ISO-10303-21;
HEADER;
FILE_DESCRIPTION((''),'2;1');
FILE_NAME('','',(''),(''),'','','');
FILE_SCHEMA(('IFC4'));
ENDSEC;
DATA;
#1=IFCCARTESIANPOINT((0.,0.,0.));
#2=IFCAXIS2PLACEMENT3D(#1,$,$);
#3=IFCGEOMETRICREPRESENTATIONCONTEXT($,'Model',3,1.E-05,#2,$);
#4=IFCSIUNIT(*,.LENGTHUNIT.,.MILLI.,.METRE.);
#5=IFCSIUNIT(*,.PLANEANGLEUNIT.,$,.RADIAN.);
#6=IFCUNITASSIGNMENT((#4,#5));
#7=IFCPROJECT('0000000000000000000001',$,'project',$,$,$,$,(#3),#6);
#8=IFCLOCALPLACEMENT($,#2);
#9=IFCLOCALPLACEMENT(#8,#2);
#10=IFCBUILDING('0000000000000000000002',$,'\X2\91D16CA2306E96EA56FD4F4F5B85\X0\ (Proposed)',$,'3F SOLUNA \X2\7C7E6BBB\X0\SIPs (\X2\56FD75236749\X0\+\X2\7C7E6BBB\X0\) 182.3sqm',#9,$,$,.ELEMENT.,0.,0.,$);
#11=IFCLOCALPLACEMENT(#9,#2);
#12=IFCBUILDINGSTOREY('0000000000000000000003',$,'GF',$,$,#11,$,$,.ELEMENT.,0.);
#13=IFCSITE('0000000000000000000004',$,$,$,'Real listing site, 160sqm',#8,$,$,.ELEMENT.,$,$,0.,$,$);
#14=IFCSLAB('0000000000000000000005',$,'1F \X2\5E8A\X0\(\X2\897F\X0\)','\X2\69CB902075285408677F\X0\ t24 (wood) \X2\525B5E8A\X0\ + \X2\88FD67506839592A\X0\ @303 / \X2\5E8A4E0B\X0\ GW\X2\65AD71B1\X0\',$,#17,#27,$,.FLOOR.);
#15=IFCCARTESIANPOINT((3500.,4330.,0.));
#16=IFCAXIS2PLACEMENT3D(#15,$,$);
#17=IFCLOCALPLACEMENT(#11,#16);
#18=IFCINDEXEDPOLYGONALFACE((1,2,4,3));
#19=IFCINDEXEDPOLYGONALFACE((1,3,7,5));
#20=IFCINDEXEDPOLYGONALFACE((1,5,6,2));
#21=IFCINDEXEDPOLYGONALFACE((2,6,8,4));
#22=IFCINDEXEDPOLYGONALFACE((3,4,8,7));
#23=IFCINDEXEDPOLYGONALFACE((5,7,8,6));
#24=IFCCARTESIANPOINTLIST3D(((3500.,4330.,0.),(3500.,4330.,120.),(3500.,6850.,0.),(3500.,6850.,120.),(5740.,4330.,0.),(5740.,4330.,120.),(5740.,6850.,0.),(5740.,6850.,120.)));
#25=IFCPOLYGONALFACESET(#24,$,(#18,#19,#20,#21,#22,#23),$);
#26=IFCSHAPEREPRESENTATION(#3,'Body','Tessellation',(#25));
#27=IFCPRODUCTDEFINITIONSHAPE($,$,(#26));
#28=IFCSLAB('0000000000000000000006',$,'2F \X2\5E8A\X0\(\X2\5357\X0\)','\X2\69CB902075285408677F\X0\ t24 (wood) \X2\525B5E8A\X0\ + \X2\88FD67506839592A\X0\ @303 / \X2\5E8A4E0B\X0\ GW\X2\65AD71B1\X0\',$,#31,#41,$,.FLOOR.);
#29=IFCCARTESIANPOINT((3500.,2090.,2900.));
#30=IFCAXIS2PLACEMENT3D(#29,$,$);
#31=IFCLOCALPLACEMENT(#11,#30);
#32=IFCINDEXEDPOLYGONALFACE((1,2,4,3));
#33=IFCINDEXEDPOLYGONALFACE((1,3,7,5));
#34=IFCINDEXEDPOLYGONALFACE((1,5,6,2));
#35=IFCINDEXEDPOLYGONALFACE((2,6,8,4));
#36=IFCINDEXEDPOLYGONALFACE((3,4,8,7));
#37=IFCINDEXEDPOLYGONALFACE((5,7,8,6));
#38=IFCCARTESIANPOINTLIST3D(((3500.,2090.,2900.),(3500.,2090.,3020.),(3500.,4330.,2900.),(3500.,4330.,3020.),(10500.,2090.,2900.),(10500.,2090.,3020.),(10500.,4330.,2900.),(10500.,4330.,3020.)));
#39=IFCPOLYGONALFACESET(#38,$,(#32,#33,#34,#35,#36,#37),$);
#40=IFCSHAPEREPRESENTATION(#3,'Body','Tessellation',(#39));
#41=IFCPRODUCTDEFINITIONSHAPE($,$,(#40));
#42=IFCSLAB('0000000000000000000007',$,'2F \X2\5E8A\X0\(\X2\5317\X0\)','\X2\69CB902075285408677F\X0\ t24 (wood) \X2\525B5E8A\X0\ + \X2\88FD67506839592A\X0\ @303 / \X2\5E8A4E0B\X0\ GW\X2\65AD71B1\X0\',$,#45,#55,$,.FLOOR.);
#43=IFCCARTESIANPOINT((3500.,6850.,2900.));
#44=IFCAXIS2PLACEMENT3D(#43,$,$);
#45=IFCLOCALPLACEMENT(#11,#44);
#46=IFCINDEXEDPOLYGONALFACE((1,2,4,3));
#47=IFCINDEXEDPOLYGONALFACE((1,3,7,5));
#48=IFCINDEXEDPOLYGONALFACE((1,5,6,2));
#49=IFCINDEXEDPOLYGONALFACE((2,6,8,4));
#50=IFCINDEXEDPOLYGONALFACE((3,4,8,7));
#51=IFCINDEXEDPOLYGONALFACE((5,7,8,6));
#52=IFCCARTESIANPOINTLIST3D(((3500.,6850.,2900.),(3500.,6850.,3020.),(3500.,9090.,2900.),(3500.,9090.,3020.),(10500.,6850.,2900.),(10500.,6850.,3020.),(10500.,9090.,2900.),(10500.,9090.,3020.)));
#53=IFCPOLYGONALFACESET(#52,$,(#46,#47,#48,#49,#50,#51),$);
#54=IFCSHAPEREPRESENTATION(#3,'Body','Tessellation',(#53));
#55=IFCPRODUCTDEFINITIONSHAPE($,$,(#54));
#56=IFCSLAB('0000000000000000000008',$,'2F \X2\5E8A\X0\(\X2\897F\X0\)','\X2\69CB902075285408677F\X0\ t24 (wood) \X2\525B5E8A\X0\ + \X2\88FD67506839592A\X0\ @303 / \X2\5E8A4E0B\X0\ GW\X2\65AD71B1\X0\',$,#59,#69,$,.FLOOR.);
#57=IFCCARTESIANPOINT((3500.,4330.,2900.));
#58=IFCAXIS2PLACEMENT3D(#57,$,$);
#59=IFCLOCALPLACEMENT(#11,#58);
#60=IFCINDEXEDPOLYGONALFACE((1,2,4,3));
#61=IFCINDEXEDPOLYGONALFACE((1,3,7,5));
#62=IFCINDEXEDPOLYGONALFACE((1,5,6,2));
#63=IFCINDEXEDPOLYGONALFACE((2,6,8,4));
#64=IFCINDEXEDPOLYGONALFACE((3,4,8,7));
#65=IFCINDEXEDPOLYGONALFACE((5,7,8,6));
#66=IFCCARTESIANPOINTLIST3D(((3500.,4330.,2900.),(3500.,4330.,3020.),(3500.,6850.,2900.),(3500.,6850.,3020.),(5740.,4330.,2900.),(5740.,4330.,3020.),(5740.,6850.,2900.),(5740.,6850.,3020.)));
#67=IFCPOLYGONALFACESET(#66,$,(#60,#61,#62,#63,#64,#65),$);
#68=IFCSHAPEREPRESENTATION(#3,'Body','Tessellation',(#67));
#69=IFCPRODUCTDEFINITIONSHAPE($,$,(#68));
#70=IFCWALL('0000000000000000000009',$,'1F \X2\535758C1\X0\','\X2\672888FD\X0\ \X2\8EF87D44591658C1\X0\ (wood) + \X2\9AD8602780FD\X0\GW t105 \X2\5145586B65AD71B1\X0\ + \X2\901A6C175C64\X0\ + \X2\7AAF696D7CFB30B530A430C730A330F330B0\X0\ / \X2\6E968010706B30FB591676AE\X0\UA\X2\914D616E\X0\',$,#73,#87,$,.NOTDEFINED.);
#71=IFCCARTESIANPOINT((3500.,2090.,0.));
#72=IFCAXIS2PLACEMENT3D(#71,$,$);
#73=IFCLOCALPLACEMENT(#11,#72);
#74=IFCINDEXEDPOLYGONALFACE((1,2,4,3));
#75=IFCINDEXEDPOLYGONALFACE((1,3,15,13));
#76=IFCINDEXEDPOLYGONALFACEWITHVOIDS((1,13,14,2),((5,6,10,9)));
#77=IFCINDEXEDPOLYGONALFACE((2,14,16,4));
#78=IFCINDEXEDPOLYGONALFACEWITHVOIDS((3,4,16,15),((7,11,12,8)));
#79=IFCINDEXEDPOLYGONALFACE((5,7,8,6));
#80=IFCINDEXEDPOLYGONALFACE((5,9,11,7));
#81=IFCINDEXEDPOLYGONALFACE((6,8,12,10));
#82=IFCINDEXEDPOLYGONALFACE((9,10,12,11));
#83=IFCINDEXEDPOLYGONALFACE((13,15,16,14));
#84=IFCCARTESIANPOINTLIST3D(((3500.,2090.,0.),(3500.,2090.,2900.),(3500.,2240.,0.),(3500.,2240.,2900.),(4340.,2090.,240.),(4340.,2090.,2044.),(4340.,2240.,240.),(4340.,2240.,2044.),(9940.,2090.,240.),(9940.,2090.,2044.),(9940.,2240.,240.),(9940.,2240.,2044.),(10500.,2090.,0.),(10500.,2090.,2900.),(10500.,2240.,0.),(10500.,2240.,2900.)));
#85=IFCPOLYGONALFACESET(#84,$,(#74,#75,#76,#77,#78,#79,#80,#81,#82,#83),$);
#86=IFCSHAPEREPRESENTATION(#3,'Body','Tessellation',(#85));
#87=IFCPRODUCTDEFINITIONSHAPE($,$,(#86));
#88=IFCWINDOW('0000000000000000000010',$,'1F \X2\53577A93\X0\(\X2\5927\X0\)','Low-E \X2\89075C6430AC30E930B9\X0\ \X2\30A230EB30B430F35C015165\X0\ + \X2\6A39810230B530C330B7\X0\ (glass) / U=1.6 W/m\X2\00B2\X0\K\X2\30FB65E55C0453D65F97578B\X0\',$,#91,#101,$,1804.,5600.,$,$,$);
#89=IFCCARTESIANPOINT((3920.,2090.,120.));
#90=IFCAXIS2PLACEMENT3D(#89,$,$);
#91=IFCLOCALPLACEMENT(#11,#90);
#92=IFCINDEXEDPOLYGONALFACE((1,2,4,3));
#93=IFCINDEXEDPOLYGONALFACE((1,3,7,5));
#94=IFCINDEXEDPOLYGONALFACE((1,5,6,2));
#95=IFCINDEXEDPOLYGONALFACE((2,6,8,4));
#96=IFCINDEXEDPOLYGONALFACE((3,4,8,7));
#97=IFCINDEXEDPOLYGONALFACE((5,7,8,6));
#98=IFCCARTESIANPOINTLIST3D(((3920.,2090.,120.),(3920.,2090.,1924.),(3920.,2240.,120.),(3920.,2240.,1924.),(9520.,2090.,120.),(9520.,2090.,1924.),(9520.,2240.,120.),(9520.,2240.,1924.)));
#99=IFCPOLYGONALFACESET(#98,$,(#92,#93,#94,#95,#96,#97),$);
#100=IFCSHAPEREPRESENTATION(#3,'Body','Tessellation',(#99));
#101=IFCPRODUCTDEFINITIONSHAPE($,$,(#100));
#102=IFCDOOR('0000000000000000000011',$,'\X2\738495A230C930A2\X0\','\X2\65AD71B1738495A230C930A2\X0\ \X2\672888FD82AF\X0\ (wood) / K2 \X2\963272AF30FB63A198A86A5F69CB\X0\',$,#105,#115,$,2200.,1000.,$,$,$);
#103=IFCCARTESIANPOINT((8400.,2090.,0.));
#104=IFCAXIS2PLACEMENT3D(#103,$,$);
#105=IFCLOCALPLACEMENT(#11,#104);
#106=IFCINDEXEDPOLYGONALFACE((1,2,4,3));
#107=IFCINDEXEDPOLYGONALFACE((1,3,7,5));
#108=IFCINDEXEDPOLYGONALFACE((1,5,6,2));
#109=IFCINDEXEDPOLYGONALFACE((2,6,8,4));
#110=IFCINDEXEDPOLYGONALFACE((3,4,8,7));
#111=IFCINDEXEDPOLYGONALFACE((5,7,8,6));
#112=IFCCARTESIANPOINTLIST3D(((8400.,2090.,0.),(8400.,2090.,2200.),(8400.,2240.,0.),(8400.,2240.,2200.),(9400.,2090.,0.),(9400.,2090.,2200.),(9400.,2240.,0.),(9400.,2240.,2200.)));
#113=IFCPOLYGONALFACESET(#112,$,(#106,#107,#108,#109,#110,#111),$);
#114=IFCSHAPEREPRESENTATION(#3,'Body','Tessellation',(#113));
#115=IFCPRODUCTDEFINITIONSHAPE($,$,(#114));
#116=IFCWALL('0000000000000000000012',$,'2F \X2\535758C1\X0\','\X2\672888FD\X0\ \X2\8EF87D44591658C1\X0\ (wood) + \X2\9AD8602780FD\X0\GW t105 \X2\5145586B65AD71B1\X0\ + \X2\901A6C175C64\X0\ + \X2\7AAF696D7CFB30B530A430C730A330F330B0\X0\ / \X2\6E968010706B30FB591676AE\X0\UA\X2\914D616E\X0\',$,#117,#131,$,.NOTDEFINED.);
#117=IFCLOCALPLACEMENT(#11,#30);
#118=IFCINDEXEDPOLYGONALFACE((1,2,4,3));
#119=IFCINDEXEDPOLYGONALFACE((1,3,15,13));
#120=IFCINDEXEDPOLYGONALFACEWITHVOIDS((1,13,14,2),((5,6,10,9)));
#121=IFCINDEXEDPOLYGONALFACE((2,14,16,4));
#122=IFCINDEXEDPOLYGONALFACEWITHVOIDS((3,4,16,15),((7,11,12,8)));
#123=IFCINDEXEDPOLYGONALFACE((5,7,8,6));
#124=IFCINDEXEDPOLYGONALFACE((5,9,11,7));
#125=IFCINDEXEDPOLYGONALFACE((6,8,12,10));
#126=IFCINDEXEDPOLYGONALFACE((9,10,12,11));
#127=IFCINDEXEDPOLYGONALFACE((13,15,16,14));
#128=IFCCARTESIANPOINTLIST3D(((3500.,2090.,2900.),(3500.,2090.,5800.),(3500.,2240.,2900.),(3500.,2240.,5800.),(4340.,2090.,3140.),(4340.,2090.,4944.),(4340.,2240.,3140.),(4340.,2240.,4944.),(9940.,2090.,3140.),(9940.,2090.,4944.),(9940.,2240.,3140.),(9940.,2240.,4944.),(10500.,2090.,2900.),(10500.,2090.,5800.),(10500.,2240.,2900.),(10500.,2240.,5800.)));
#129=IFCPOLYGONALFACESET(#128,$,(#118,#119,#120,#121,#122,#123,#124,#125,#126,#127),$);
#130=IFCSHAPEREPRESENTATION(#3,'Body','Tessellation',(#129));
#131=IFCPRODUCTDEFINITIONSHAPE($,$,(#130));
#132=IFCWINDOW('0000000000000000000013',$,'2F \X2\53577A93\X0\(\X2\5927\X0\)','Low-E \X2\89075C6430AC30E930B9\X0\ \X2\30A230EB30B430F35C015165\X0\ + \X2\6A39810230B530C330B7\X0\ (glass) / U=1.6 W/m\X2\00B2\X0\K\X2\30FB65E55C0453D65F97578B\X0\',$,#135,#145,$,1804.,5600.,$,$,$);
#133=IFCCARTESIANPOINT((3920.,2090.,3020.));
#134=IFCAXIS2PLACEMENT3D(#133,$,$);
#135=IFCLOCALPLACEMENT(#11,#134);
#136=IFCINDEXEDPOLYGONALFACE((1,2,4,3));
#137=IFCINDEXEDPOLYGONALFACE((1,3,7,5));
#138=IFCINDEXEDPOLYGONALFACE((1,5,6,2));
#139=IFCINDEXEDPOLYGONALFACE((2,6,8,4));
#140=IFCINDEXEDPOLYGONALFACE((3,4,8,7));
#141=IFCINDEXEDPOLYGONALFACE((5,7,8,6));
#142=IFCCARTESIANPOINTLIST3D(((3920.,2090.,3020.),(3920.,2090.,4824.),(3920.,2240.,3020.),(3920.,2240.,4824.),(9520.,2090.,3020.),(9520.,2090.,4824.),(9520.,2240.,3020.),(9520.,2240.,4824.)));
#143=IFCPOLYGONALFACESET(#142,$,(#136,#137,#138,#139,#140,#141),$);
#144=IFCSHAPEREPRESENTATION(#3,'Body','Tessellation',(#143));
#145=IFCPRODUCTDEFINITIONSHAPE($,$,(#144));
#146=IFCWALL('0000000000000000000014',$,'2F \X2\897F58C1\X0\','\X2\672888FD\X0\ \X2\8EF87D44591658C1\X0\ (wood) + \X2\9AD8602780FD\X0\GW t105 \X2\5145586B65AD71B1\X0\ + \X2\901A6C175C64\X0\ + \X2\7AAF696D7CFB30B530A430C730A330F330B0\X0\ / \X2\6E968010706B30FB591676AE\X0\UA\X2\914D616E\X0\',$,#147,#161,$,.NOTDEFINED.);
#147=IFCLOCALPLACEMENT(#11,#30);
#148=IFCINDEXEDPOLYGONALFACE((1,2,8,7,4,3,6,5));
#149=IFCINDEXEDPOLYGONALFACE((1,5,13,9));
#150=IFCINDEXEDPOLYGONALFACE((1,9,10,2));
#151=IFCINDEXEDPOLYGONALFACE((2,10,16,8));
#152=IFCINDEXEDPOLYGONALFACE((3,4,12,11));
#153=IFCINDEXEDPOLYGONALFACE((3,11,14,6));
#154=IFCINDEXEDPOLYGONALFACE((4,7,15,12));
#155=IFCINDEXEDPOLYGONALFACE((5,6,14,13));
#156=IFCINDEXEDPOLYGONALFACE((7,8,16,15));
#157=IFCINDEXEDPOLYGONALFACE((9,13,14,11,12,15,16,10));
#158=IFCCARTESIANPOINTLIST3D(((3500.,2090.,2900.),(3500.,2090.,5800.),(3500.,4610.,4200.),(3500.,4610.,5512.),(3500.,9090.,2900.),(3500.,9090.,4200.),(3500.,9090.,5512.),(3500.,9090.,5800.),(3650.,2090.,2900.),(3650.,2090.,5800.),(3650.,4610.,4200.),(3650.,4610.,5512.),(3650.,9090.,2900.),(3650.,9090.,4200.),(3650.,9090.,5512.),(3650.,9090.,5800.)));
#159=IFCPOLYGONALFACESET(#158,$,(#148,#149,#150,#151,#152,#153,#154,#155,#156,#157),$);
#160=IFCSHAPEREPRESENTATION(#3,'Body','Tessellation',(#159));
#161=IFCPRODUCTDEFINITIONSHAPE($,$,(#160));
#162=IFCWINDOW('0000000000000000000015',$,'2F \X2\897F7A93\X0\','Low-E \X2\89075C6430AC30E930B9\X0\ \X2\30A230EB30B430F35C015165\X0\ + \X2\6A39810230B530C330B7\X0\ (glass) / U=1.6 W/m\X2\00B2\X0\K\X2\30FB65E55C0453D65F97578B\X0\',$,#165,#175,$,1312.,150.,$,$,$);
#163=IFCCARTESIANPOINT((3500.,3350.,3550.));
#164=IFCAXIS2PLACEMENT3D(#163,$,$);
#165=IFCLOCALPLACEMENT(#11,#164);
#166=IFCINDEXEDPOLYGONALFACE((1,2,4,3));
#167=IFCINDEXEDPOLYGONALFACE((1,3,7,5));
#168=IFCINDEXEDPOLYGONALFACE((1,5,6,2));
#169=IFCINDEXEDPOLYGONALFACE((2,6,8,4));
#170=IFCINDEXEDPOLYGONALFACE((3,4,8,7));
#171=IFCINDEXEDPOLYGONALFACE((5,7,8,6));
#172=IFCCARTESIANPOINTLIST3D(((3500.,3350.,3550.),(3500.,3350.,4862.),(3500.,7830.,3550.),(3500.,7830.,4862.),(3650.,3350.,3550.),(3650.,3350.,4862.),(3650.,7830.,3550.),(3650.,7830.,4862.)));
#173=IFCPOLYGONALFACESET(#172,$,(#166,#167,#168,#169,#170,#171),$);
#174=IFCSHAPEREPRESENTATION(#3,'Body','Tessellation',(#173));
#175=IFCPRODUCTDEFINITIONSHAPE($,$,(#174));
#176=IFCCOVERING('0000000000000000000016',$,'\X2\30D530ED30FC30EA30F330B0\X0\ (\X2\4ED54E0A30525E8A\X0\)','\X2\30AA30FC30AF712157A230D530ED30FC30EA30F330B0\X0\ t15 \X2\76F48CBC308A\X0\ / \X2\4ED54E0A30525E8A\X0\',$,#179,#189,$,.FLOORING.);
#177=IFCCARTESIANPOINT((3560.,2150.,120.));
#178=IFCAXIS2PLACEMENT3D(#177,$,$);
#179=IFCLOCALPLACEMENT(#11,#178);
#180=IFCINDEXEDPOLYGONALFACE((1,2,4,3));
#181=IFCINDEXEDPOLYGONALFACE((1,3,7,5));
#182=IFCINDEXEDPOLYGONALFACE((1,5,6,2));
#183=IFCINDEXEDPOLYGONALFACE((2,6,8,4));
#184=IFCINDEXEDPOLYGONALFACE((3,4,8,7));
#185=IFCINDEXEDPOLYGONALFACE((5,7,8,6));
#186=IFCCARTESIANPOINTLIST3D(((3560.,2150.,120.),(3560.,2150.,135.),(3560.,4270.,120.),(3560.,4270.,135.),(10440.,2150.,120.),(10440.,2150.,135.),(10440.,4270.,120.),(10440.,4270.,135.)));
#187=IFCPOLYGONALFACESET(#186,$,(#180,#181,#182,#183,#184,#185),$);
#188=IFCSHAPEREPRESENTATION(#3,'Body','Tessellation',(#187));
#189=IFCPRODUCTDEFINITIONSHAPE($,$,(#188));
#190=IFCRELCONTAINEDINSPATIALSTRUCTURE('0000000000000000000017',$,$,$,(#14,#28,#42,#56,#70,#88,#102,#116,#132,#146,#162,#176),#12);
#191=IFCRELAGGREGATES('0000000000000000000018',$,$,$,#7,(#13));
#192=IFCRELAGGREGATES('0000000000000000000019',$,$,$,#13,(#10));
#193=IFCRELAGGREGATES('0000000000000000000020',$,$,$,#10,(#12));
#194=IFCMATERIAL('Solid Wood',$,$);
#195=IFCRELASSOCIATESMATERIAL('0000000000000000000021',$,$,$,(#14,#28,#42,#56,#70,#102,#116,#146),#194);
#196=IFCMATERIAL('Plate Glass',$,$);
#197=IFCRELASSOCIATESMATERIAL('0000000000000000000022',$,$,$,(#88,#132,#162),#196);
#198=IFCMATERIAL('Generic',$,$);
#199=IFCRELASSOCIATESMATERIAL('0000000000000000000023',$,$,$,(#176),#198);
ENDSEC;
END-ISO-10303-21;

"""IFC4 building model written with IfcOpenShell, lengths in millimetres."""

from ifc_helpers import new_model, si_unit, frame, frame_2d, origin, place, context, project, spatial, rectangle, extrude, material, element, fill, save


model = new_model("IFC4")

# Units and contexts
model_context = context("Model", 3, precision=1e-05, world=origin())
ifc_project = project(units=[si_unit("LENGTHUNIT", "METRE", prefix="MILLI"), si_unit("PLANEANGLEUNIT", "RADIAN")], contexts=[model_context])

# Site, building, storey
site_placement = place(None, origin())
site = spatial("IfcSite", under=ifc_project, at=site_placement, ObjectType="Real listing site, 160sqm", CompositionType="ELEMENT", RefElevation=0.0)
building_placement = place(site_placement, origin())
building = spatial("IfcBuilding", under=site, at=building_placement, Name="金沢の雪国住宅 (Proposed)", ObjectType="3F SOLUNA 籾殻SIPs (国産杉+籾殻) 182.3sqm", CompositionType="ELEMENT", ElevationOfRefHeight=0.0, ElevationOfTerrain=0.0)
storey_placement = place(building_placement, origin())
storey = spatial("IfcBuildingStorey", under=building, at=storey_placement, Name="GF", CompositionType="ELEMENT", Elevation=0.0)

# Slabs
ifc_material_1 = material(Name="Solid Wood")
slab_1_placement = place(storey_placement, frame((3500.0, 4330.0, 0.0)))
element("IfcSlab", 1, at=slab_1_placement, inside=storey, material=ifc_material_1, Name="1F 床(西)", Description="構造用合板 t24 (wood) 剛床 + 製材根太 @303 / 床下 GW断熱", PredefinedType="FLOOR", context=model_context, shape_type="SweptSolid", body=[
    extrude(rectangle(XDim=2240.0, YDim=2520.0, at=frame_2d((1120.0, 1260.0))), frame((3500.0, 4330.0, 0.0)), (0.0, 0.0, 1.0), 120.0),
])
slab_2_placement = place(storey_placement, frame((3500.0, 2090.0, 2900.0)))
element("IfcSlab", 2, at=slab_2_placement, inside=storey, material=ifc_material_1, Name="2F 床(南)", Description="構造用合板 t24 (wood) 剛床 + 製材根太 @303 / 床下 GW断熱", PredefinedType="FLOOR", context=model_context, shape_type="SweptSolid", body=[
    extrude(rectangle(XDim=7000.0, YDim=2240.0, at=frame_2d((3500.0, 1120.0))), frame((3500.0, 2090.0, 2900.0)), (0.0, 0.0, 1.0), 120.0),
])
slab_3_placement = place(storey_placement, frame((3500.0, 6850.0, 2900.0)))
element("IfcSlab", 3, at=slab_3_placement, inside=storey, material=ifc_material_1, Name="2F 床(北)", Description="構造用合板 t24 (wood) 剛床 + 製材根太 @303 / 床下 GW断熱", PredefinedType="FLOOR", context=model_context, shape_type="SweptSolid", body=[
    extrude(rectangle(XDim=7000.0, YDim=2240.0, at=frame_2d((3500.0, 1120.0))), frame((3500.0, 6850.0, 2900.0)), (0.0, 0.0, 1.0), 120.0),
])
slab_4_placement = place(storey_placement, frame((3500.0, 4330.0, 2900.0)))
element("IfcSlab", 4, at=slab_4_placement, inside=storey, material=ifc_material_1, Name="2F 床(西)", Description="構造用合板 t24 (wood) 剛床 + 製材根太 @303 / 床下 GW断熱", PredefinedType="FLOOR", context=model_context, shape_type="SweptSolid", body=[
    extrude(rectangle(XDim=2240.0, YDim=2520.0, at=frame_2d((1120.0, 1260.0))), frame((3500.0, 4330.0, 2900.0)), (0.0, 0.0, 1.0), 120.0),
])

# Wall, openings, window, door
wall_1_placement = place(storey_placement, frame((3500.0, 2090.0, 0.0)))
wall_1 = element("IfcWall", 5, at=wall_1_placement, inside=storey, material=ifc_material_1, Name="1F 南壁", Description="木製 軸組外壁 (wood) + 高性能GW t105 充填断熱 + 通気層 + 窯業系サイディング / 準耐火・外皮UA配慮", PredefinedType="NOTDEFINED", context=model_context, shape_type="SweptSolid", body=[
    extrude(rectangle(XDim=7000.0, YDim=150.0, at=frame_2d((3500.0, 75.0))), frame((3500.0, 2090.0, 0.0)), (0.0, 0.0, 1.0), 2900.0),
])
opening_1_placement = place(storey_placement, frame((3920.0, 2090.0, 120.0)))
opening_1 = element("IfcOpeningElement", 6, at=opening_1_placement, cuts=wall_1, PredefinedType="NOTDEFINED", context=model_context, shape_type="SweptSolid", body=[
    extrude(rectangle(XDim=5600.0, YDim=150.0, at=frame_2d((2800.0, 75.0))), frame((3920.0, 2090.0, 120.0)), (0.0, 0.0, 1.0), 1804.0),
])
opening_2_placement = place(storey_placement, frame((8400.0, 2090.0, 0.0)))
opening_2 = element("IfcOpeningElement", 7, at=opening_2_placement, cuts=wall_1, PredefinedType="NOTDEFINED", context=model_context, shape_type="SweptSolid", body=[
    extrude(rectangle(XDim=1000.0, YDim=150.0, at=frame_2d((500.0, 75.0))), frame((8400.0, 2090.0, 0.0)), (0.0, 0.0, 1.0), 2200.0),
])
ifc_material_2 = material(Name="Plate Glass")
window_1_placement = place(storey_placement, frame((3920.0, 2090.0, 120.0)))
window_1 = element("IfcWindow", 8, at=window_1_placement, inside=storey, material=ifc_material_2, Name="1F 南窓(大)", Description="Low-E 複層ガラス アルゴン封入 + 樹脂サッシ (glass) / U=1.6 W/m²K・日射取得型", OverallHeight=1804.0, OverallWidth=5600.0, context=model_context, shape_type="SweptSolid", body=[
    extrude(rectangle(XDim=5600.0, YDim=150.0, at=frame_2d((2800.0, 75.0))), frame((3920.0, 2090.0, 120.0)), (0.0, 0.0, 1.0), 1804.0),
])
fill(opening_1, window_1)
door_placement = place(storey_placement, frame((8400.0, 2090.0, 0.0)))
door = element("IfcDoor", 9, at=door_placement, inside=storey, material=ifc_material_1, Name="玄関ドア", Description="断熱玄関ドア 木製芯 (wood) / K2 防犯・採風機構", OverallHeight=2200.0, OverallWidth=1000.0, context=model_context, shape_type="SweptSolid", body=[
    extrude(rectangle(XDim=1000.0, YDim=150.0, at=frame_2d((500.0, 75.0))), frame((8400.0, 2090.0, 0.0)), (0.0, 0.0, 1.0), 2200.0),
])
fill(opening_2, door)

# Wall, opening, window
wall_2_placement = place(storey_placement, frame((3500.0, 2090.0, 2900.0)))
wall_2 = element("IfcWall", 10, at=wall_2_placement, inside=storey, material=ifc_material_1, Name="2F 南壁", Description="木製 軸組外壁 (wood) + 高性能GW t105 充填断熱 + 通気層 + 窯業系サイディング / 準耐火・外皮UA配慮", PredefinedType="NOTDEFINED", context=model_context, shape_type="SweptSolid", body=[
    extrude(rectangle(XDim=7000.0, YDim=150.0, at=frame_2d((3500.0, 75.0))), frame((3500.0, 2090.0, 2900.0)), (0.0, 0.0, 1.0), 2900.0),
])
opening_3_placement = place(storey_placement, frame((3920.0, 2090.0, 3020.0)))
opening_3 = element("IfcOpeningElement", 11, at=opening_3_placement, cuts=wall_2, PredefinedType="NOTDEFINED", context=model_context, shape_type="SweptSolid", body=[
    extrude(rectangle(XDim=5600.0, YDim=150.0, at=frame_2d((2800.0, 75.0))), frame((3920.0, 2090.0, 3020.0)), (0.0, 0.0, 1.0), 1804.0),
])
window_2_placement = place(storey_placement, frame((3920.0, 2090.0, 3020.0)))
window_2 = element("IfcWindow", 12, at=window_2_placement, inside=storey, material=ifc_material_2, Name="2F 南窓(大)", Description="Low-E 複層ガラス アルゴン封入 + 樹脂サッシ (glass) / U=1.6 W/m²K・日射取得型", OverallHeight=1804.0, OverallWidth=5600.0, context=model_context, shape_type="SweptSolid", body=[
    extrude(rectangle(XDim=5600.0, YDim=150.0, at=frame_2d((2800.0, 75.0))), frame((3920.0, 2090.0, 3020.0)), (0.0, 0.0, 1.0), 1804.0),
])
fill(opening_3, window_2)

# Wall, opening, window
wall_3_placement = place(storey_placement, frame((3500.0, 2090.0, 2900.0)))
wall_3 = element("IfcWall", 13, at=wall_3_placement, inside=storey, material=ifc_material_1, Name="2F 西壁", Description="木製 軸組外壁 (wood) + 高性能GW t105 充填断熱 + 通気層 + 窯業系サイディング / 準耐火・外皮UA配慮", PredefinedType="NOTDEFINED", context=model_context, shape_type="SweptSolid", body=[
    extrude(rectangle(XDim=150.0, YDim=7000.0, at=frame_2d((75.0, 3500.0))), frame((3500.0, 2090.0, 2900.0)), (0.0, 0.0, 1.0), 2900.0),
])
opening_4_placement = place(storey_placement, frame((3500.0, 3350.0, 3550.0)))
opening_4 = element("IfcOpeningElement", 14, at=opening_4_placement, cuts=wall_3, PredefinedType="NOTDEFINED", context=model_context, shape_type="SweptSolid", body=[
    extrude(rectangle(XDim=150.0, YDim=4480.0, at=frame_2d((75.0, 2240.0))), frame((3500.0, 3350.0, 3550.0)), (0.0, 0.0, 1.0), 1312.0),
])
window_3_placement = place(storey_placement, frame((3500.0, 3350.0, 3550.0)))
window_3 = element("IfcWindow", 15, at=window_3_placement, inside=storey, material=ifc_material_2, Name="2F 西窓", Description="Low-E 複層ガラス アルゴン封入 + 樹脂サッシ (glass) / U=1.6 W/m²K・日射取得型", OverallHeight=1312.0, OverallWidth=150.0, context=model_context, shape_type="SweptSolid", body=[
    extrude(rectangle(XDim=150.0, YDim=4480.0, at=frame_2d((75.0, 2240.0))), frame((3500.0, 3350.0, 3550.0)), (0.0, 0.0, 1.0), 1312.0),
])
fill(opening_4, window_3)

# Covering
ifc_material_3 = material(Name="Generic")
covering_1_placement = place(storey_placement, frame((3560.0, 2150.0, 120.0)))
element("IfcCovering", 16, at=covering_1_placement, inside=storey, material=ifc_material_3, Name="フローリング (仕上げ床)", Description="オーク無垢フローリング t15 直貼り / 仕上げ床", PredefinedType="FLOORING", context=model_context, shape_type="SweptSolid", body=[
    extrude(rectangle(XDim=6880.0, YDim=2120.0, at=frame_2d((3440.0, 1060.0))), frame((3560.0, 2150.0, 120.0)), (0.0, 0.0, 1.0), 15.0),
])

save(model, "model.ifc")
